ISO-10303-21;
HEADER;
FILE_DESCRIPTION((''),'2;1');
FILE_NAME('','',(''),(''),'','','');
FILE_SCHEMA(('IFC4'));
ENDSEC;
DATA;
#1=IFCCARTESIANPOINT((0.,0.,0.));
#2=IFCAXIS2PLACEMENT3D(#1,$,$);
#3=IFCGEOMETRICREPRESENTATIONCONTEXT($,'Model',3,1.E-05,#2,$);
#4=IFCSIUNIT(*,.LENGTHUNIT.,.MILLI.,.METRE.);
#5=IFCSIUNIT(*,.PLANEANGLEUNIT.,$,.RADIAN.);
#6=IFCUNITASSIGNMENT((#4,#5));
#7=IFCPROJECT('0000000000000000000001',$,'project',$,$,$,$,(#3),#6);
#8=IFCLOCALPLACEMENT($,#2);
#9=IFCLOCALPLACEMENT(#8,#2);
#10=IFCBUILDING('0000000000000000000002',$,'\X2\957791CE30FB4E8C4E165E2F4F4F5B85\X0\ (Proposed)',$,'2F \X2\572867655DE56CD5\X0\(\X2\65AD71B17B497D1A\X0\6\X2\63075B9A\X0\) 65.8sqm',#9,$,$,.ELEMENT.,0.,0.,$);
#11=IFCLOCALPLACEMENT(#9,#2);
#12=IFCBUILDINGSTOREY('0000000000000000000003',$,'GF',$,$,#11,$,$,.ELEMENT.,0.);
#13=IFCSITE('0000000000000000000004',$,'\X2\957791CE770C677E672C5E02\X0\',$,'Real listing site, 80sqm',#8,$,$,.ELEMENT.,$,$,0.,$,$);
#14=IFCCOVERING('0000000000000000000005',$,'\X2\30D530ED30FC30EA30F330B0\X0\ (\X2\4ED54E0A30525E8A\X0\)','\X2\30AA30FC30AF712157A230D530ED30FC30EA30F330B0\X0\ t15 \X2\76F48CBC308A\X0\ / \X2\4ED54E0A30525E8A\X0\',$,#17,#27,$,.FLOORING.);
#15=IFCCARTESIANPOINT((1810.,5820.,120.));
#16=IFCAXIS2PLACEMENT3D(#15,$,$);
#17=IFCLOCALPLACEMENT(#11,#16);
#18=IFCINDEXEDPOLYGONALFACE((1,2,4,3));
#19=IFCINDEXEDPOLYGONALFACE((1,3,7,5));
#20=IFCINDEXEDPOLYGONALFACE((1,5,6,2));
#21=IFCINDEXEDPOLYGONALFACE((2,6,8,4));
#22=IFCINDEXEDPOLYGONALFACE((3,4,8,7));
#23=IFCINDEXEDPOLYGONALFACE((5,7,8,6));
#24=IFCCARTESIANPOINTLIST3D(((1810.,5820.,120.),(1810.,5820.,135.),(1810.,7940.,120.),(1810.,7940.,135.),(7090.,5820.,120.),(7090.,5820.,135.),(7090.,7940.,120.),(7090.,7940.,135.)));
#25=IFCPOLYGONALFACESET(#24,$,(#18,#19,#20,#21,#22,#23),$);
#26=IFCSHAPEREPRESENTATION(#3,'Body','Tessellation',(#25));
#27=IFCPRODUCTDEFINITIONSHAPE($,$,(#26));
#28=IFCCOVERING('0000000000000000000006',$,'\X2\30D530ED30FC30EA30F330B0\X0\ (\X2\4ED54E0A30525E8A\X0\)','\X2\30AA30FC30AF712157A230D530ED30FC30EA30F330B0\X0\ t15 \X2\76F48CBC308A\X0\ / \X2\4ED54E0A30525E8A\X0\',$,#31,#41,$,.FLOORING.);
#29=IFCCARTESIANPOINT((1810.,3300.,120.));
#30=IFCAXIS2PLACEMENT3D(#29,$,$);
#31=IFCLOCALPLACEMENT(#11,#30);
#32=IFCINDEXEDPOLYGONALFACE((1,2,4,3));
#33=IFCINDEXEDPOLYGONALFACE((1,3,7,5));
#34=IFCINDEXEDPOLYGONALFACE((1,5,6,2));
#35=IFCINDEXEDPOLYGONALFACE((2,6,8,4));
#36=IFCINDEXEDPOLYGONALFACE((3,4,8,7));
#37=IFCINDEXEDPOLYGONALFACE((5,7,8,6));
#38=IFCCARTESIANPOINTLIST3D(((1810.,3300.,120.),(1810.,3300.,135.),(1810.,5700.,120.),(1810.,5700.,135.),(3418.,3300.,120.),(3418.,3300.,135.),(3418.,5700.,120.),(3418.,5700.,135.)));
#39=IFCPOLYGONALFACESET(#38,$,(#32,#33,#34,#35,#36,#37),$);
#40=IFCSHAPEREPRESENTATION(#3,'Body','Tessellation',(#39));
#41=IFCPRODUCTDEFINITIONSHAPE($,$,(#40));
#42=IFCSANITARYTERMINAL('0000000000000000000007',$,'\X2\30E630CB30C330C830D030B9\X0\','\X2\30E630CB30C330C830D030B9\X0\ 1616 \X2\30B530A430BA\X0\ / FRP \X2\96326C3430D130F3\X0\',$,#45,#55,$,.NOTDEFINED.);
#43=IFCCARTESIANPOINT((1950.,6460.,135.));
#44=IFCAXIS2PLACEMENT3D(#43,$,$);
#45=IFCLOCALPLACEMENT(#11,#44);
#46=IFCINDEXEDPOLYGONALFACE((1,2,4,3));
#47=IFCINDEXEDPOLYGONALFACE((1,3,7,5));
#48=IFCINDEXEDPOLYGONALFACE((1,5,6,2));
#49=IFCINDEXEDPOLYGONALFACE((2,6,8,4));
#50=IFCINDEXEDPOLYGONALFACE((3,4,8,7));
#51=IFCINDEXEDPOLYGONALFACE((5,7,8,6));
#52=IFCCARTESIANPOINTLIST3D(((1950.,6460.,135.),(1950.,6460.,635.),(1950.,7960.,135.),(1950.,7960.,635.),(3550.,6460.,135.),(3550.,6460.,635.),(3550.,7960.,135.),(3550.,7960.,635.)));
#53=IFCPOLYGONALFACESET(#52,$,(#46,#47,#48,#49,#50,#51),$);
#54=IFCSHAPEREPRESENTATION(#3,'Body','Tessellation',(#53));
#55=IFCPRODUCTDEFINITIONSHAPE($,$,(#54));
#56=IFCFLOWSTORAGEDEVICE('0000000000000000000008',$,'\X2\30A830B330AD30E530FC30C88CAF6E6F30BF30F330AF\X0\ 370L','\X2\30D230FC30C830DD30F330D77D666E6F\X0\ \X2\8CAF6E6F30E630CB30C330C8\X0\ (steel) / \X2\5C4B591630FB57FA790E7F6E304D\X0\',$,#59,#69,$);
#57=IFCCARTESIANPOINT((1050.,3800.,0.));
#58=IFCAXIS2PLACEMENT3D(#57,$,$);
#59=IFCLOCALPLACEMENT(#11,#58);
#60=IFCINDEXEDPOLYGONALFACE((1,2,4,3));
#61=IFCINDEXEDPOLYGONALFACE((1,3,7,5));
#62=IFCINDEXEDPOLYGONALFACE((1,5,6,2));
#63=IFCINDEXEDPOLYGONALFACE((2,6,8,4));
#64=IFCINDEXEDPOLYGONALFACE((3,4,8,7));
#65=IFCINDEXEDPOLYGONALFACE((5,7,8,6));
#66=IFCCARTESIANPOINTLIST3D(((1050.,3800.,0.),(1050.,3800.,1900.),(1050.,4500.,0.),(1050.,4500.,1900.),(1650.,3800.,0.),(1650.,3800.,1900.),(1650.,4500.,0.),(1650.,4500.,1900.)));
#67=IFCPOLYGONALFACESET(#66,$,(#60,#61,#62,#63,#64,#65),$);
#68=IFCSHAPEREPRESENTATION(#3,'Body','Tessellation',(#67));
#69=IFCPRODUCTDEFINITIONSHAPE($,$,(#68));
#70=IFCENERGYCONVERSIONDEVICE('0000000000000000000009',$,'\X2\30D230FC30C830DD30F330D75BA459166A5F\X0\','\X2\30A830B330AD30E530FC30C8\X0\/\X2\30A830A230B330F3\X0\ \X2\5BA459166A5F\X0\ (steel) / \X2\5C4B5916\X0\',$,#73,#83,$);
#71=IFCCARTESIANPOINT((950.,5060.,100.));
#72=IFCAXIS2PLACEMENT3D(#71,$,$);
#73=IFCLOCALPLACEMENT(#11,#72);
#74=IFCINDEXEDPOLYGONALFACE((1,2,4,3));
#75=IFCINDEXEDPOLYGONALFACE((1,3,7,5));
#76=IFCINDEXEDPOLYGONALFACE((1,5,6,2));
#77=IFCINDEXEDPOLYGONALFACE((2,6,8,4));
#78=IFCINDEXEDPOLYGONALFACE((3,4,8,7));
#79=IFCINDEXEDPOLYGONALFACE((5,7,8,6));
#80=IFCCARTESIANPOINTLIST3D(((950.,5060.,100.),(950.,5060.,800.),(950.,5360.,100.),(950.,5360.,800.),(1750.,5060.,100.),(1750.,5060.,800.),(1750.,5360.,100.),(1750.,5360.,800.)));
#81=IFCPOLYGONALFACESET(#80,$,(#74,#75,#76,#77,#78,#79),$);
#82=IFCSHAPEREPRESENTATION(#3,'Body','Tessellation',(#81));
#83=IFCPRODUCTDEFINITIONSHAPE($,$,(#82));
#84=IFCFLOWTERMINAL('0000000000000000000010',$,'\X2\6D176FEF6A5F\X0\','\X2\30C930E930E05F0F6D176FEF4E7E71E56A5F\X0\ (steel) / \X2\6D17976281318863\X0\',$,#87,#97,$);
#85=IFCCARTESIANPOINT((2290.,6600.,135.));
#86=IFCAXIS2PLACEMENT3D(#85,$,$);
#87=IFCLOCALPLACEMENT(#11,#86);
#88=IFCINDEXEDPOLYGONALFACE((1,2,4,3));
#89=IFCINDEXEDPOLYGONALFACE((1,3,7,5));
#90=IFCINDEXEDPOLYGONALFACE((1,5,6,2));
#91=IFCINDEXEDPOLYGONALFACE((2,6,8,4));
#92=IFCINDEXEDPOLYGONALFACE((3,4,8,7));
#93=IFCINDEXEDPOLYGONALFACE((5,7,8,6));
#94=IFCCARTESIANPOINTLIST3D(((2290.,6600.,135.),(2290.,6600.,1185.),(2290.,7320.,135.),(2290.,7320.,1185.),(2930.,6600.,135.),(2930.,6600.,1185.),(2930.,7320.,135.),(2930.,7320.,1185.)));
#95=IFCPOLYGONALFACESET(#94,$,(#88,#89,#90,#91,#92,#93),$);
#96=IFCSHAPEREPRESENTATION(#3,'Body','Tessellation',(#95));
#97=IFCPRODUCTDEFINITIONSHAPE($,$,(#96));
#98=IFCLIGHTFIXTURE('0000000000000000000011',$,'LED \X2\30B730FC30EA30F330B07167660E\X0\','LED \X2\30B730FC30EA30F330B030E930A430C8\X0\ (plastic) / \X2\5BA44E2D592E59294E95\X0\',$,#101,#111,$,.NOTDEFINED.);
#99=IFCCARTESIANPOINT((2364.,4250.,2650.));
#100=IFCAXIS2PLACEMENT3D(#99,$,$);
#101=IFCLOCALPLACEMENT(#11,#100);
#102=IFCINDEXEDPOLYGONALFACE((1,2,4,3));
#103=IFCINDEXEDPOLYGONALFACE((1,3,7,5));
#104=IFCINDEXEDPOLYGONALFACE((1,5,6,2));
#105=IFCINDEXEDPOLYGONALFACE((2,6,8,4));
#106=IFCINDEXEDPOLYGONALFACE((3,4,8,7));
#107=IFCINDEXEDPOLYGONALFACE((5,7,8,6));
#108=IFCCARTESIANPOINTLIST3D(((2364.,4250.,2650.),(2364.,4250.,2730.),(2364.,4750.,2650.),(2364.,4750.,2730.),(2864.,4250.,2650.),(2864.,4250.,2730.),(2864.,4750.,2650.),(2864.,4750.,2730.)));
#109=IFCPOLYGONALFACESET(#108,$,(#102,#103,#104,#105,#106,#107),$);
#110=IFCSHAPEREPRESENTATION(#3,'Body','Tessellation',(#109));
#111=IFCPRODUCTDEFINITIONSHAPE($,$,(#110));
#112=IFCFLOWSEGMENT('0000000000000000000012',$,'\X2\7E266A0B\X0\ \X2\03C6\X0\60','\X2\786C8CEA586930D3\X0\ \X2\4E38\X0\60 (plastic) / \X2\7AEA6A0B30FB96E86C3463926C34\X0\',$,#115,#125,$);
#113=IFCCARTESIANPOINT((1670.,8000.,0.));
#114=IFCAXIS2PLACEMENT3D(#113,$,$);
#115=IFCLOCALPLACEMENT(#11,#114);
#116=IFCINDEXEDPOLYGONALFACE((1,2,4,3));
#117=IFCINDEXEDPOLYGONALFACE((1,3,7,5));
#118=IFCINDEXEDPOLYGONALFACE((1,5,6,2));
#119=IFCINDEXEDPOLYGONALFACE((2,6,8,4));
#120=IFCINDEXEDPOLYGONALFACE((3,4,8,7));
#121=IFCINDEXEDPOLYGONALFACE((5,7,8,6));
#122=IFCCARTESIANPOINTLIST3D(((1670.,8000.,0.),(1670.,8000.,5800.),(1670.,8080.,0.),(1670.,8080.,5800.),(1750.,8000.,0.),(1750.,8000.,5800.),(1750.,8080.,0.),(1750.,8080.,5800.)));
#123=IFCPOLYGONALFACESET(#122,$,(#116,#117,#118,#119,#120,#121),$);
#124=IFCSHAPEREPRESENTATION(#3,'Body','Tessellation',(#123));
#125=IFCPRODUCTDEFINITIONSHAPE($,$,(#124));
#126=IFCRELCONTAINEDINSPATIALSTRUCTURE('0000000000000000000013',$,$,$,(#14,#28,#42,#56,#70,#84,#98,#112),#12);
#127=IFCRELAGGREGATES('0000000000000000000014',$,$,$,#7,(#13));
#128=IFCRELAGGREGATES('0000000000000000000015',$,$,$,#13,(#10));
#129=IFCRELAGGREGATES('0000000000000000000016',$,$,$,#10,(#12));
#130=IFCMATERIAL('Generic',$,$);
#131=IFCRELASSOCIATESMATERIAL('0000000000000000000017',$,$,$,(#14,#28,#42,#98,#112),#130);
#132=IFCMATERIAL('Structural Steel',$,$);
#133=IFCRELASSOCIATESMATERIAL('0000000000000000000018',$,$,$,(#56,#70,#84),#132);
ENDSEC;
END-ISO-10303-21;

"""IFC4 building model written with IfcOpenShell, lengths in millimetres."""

from ifc_helpers import new_model, si_unit, frame, frame_2d, origin, place, context, project, spatial, rectangle, extrude, material, element, save


model = new_model("IFC4")

# Units and contexts
model_context = context("Model", 3, precision=1e-05, world=origin())
ifc_project = project(units=[si_unit("LENGTHUNIT", "METRE", prefix="MILLI"), si_unit("PLANEANGLEUNIT", "RADIAN")], contexts=[model_context])

# Site, building, storey
site_placement = place(None, origin())
site = spatial("IfcSite", under=ifc_project, at=site_placement, Name="長野県松本市", ObjectType="Real listing site, 80sqm", CompositionType="ELEMENT", RefElevation=0.0)
building_placement = place(site_placement, origin())
building = spatial("IfcBuilding", under=site, at=building_placement, Name="長野・二世帯住宅 (Proposed)", ObjectType="2F 在来工法(断熱等級6指定) 65.8sqm", CompositionType="ELEMENT", ElevationOfRefHeight=0.0, ElevationOfTerrain=0.0)
storey_placement = place(building_placement, origin())
storey = spatial("IfcBuildingStorey", under=building, at=storey_placement, Name="GF", CompositionType="ELEMENT", Elevation=0.0)

# Coverings
ifc_material_1 = material(Name="Generic")
covering_1_placement = place(storey_placement, frame((1810.0, 5820.0, 120.0)))
element("IfcCovering", 1, at=covering_1_placement, inside=storey, material=ifc_material_1, Name="フローリング (仕上げ床)", Description="オーク無垢フローリング t15 直貼り / 仕上げ床", PredefinedType="FLOORING", context=model_context, shape_type="SweptSolid", body=[
    extrude(rectangle(XDim=5280.0, YDim=2120.0, at=frame_2d((2640.0, 1060.0))), frame((1810.0, 5820.0, 120.0)), (0.0, 0.0, 1.0), 15.0),
])
covering_2_placement = place(storey_placement, frame((1810.0, 3300.0, 120.0)))
element("IfcCovering", 2, at=covering_2_placement, inside=storey, material=ifc_material_1, Name="フローリング (仕上げ床)", Description="オーク無垢フローリング t15 直貼り / 仕上げ床", PredefinedType="FLOORING", context=model_context, shape_type="SweptSolid", body=[
    extrude(rectangle(XDim=1608.0, YDim=2400.0, at=frame_2d((804.0, 1200.0))), frame((1810.0, 3300.0, 120.0)), (0.0, 0.0, 1.0), 15.0),
])

# Sanitary terminal
sanitary_terminal_placement = place(storey_placement, frame((1950.0, 6460.0, 135.0)))
element("IfcSanitaryTerminal", 3, at=sanitary_terminal_placement, inside=storey, material=ifc_material_1, Name="ユニットバス", Description="ユニットバス 1616 サイズ / FRP 防水パン", PredefinedType="NOTDEFINED", context=model_context, shape_type="SweptSolid", body=[
    extrude(rectangle(XDim=1600.0, YDim=1500.0, at=frame_2d((800.0, 750.0))), frame((1950.0, 6460.0, 135.0)), (0.0, 0.0, 1.0), 500.0),
])

# Flow storage device
ifc_material_2 = material(Name="Structural Steel")
flow_storage_device_placement = place(storey_placement, frame((1050.0, 3800.0, 0.0)))
element("IfcFlowStorageDevice", 4, at=flow_storage_device_placement, inside=storey, material=ifc_material_2, Name="エコキュート貯湯タンク 370L", Description="ヒートポンプ給湯 貯湯ユニット (steel) / 屋外・基礎置き", context=model_context, shape_type="SweptSolid", body=[
    extrude(rectangle(XDim=600.0, YDim=700.0, at=frame_2d((300.0, 350.0))), frame((1050.0, 3800.0, 0.0)), (0.0, 0.0, 1.0), 1900.0),
])

# Energy conversion device
energy_conversion_device_placement = place(storey_placement, frame((950.0, 5060.0, 100.0)))
element("IfcEnergyConversionDevice", 5, at=energy_conversion_device_placement, inside=storey, material=ifc_material_2, Name="ヒートポンプ室外機", Description="エコキュート/エアコン 室外機 (steel) / 屋外", context=model_context, shape_type="SweptSolid", body=[
    extrude(rectangle(XDim=800.0, YDim=300.0, at=frame_2d((400.0, 150.0))), frame((950.0, 5060.0, 100.0)), (0.0, 0.0, 1.0), 700.0),
])

# Flow terminal
flow_terminal_placement = place(storey_placement, frame((2290.0, 6600.0, 135.0)))
element("IfcFlowTerminal", 6, at=flow_terminal_placement, inside=storey, material=ifc_material_2, Name="洗濯機", Description="ドラム式洗濯乾燥機 (steel) / 洗面脱衣", context=model_context, shape_type="SweptSolid", body=[
    extrude(rectangle(XDim=640.0, YDim=720.0, at=frame_2d((320.0, 360.0))), frame((2290.0, 6600.0, 135.0)), (0.0, 0.0, 1.0), 1050.0),
])

# Light fixture
light_fixture_placement = place(storey_placement, frame((2364.0, 4250.0, 2650.0)))
element("IfcLightFixture", 7, at=light_fixture_placement, inside=storey, material=ifc_material_1, Name="LED シーリング照明", Description="LED シーリングライト (plastic) / 室中央天井", PredefinedType="NOTDEFINED", context=model_context, shape_type="SweptSolid", body=[
    extrude(rectangle(XDim=500.0, YDim=500.0, at=frame_2d((250.0, 250.0))), frame((2364.0, 4250.0, 2650.0)), (0.0, 0.0, 1.0), 80.0),
])

# Flow segment
flow_segment_placement = place(storey_placement, frame((1670.0, 8000.0, 0.0)))
element("IfcFlowSegment", 8, at=flow_segment_placement, inside=storey, material=ifc_material_1, Name="縦樋 φ60", Description="硬質塩ビ 丸60 (plastic) / 竪樋・雨水排水", context=model_context, shape_type="SweptSolid", body=[
    extrude(rectangle(XDim=80.0, YDim=80.0, at=frame_2d((40.0, 40.0))), frame((1670.0, 8000.0, 0.0)), (0.0, 0.0, 1.0), 5800.0),
])

save(model, "model.ifc")
